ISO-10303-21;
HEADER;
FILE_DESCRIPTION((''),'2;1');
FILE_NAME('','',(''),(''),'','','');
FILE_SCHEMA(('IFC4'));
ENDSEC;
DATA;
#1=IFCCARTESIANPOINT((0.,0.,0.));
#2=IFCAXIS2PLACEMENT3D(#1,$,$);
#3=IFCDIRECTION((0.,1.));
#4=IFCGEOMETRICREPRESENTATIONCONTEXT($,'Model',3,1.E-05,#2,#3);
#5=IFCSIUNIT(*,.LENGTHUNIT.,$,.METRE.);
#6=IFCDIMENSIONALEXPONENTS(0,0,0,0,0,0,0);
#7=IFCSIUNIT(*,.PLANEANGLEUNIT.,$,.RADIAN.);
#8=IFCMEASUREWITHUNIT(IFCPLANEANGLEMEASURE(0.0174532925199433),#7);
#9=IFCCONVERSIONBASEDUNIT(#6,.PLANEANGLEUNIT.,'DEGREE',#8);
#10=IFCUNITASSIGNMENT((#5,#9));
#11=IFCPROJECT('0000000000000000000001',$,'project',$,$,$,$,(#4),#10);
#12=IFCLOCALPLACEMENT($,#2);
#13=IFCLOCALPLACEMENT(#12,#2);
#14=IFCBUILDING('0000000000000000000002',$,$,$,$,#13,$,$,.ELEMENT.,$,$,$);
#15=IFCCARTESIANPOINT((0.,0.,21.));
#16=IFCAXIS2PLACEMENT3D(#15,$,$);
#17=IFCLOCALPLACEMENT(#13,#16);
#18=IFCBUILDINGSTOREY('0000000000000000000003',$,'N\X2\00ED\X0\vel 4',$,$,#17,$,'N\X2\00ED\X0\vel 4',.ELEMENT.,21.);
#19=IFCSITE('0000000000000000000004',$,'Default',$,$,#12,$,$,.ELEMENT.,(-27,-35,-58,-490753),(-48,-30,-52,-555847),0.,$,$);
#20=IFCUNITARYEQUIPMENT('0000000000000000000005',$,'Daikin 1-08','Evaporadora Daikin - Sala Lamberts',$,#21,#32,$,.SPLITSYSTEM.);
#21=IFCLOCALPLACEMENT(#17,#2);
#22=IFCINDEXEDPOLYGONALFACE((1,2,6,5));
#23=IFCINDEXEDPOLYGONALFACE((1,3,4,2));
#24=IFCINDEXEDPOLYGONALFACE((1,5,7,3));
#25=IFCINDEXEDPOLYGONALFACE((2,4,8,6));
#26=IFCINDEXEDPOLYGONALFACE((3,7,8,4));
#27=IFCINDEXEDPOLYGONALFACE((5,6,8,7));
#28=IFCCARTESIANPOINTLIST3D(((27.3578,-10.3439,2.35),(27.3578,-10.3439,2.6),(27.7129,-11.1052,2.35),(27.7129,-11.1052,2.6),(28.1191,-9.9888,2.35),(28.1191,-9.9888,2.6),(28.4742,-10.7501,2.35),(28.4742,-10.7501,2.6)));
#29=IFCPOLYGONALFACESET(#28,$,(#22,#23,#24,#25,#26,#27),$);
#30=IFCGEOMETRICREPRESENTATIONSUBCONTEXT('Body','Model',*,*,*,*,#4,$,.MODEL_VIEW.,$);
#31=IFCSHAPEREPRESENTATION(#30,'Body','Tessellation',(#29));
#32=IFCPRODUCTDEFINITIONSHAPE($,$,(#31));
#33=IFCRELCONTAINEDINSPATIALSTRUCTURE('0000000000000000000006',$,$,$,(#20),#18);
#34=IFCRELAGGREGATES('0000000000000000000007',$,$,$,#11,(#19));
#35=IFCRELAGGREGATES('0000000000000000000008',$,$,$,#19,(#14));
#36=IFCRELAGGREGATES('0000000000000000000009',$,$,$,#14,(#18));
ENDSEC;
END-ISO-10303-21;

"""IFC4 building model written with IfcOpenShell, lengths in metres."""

from ifc_helpers import new_model, entity, si_unit, converted_unit, direction, frame, origin, origin_2d, place, context, subcontext, project, spatial, rectangle, extrude, element, save


model = new_model("IFC4")

# Units and contexts
model_context = context("Model", 3, precision=1e-05, world=origin(), true_north=direction((0.0, 1.0)))
body_context = subcontext(model_context, "Body", "Model", "MODEL_VIEW")
ifc_project = project(units=[si_unit("LENGTHUNIT", "METRE"), converted_unit("PLANEANGLEUNIT", "DEGREE", entity("IfcPlaneAngleMeasure", 0.0174532925199433), si_unit("PLANEANGLEUNIT", "RADIAN"), dimensions=[0, 0, 0, 0, 0, 0, 0])], contexts=[model_context])

# Site, building, storey
site_placement = place(None, origin())
site = spatial("IfcSite", under=ifc_project, at=site_placement, Name="Default", CompositionType="ELEMENT", RefLatitude=(-27, -35, -58, -490753), RefLongitude=(-48, -30, -52, -555847), RefElevation=0.0)
building_placement = place(site_placement, origin())
building = spatial("IfcBuilding", under=site, at=building_placement, CompositionType="ELEMENT")
storey_placement = place(building_placement, frame((0.0, 0.0, 21.0)))
storey = spatial("IfcBuildingStorey", under=building, at=storey_placement, Name="Nível 4", LongName="Nível 4", CompositionType="ELEMENT", Elevation=21.0)

# Unitary equipment
for number, where, z_axis, x_axis, name in (
    (1, (27.916, -10.547, 23.35), (0.0, 0.0, 1.0), (0.906245, 0.422754, 0.0), "Daikin 1-08"),
):
    element("IfcUnitaryEquipment", number, at=place(None, frame(where, z_axis=z_axis, x_axis=x_axis)), inside=storey, Name=name, Description="Evaporadora Daikin - Sala Lamberts", PredefinedType="SPLITSYSTEM", context=body_context, shape_type="SweptSolid", body=[
        extrude(rectangle(XDim=0.84, YDim=0.84, at=origin_2d()), None, (0.0, 0.0, 1.0), 0.25),
    ])

save(model, "model.ifc")
